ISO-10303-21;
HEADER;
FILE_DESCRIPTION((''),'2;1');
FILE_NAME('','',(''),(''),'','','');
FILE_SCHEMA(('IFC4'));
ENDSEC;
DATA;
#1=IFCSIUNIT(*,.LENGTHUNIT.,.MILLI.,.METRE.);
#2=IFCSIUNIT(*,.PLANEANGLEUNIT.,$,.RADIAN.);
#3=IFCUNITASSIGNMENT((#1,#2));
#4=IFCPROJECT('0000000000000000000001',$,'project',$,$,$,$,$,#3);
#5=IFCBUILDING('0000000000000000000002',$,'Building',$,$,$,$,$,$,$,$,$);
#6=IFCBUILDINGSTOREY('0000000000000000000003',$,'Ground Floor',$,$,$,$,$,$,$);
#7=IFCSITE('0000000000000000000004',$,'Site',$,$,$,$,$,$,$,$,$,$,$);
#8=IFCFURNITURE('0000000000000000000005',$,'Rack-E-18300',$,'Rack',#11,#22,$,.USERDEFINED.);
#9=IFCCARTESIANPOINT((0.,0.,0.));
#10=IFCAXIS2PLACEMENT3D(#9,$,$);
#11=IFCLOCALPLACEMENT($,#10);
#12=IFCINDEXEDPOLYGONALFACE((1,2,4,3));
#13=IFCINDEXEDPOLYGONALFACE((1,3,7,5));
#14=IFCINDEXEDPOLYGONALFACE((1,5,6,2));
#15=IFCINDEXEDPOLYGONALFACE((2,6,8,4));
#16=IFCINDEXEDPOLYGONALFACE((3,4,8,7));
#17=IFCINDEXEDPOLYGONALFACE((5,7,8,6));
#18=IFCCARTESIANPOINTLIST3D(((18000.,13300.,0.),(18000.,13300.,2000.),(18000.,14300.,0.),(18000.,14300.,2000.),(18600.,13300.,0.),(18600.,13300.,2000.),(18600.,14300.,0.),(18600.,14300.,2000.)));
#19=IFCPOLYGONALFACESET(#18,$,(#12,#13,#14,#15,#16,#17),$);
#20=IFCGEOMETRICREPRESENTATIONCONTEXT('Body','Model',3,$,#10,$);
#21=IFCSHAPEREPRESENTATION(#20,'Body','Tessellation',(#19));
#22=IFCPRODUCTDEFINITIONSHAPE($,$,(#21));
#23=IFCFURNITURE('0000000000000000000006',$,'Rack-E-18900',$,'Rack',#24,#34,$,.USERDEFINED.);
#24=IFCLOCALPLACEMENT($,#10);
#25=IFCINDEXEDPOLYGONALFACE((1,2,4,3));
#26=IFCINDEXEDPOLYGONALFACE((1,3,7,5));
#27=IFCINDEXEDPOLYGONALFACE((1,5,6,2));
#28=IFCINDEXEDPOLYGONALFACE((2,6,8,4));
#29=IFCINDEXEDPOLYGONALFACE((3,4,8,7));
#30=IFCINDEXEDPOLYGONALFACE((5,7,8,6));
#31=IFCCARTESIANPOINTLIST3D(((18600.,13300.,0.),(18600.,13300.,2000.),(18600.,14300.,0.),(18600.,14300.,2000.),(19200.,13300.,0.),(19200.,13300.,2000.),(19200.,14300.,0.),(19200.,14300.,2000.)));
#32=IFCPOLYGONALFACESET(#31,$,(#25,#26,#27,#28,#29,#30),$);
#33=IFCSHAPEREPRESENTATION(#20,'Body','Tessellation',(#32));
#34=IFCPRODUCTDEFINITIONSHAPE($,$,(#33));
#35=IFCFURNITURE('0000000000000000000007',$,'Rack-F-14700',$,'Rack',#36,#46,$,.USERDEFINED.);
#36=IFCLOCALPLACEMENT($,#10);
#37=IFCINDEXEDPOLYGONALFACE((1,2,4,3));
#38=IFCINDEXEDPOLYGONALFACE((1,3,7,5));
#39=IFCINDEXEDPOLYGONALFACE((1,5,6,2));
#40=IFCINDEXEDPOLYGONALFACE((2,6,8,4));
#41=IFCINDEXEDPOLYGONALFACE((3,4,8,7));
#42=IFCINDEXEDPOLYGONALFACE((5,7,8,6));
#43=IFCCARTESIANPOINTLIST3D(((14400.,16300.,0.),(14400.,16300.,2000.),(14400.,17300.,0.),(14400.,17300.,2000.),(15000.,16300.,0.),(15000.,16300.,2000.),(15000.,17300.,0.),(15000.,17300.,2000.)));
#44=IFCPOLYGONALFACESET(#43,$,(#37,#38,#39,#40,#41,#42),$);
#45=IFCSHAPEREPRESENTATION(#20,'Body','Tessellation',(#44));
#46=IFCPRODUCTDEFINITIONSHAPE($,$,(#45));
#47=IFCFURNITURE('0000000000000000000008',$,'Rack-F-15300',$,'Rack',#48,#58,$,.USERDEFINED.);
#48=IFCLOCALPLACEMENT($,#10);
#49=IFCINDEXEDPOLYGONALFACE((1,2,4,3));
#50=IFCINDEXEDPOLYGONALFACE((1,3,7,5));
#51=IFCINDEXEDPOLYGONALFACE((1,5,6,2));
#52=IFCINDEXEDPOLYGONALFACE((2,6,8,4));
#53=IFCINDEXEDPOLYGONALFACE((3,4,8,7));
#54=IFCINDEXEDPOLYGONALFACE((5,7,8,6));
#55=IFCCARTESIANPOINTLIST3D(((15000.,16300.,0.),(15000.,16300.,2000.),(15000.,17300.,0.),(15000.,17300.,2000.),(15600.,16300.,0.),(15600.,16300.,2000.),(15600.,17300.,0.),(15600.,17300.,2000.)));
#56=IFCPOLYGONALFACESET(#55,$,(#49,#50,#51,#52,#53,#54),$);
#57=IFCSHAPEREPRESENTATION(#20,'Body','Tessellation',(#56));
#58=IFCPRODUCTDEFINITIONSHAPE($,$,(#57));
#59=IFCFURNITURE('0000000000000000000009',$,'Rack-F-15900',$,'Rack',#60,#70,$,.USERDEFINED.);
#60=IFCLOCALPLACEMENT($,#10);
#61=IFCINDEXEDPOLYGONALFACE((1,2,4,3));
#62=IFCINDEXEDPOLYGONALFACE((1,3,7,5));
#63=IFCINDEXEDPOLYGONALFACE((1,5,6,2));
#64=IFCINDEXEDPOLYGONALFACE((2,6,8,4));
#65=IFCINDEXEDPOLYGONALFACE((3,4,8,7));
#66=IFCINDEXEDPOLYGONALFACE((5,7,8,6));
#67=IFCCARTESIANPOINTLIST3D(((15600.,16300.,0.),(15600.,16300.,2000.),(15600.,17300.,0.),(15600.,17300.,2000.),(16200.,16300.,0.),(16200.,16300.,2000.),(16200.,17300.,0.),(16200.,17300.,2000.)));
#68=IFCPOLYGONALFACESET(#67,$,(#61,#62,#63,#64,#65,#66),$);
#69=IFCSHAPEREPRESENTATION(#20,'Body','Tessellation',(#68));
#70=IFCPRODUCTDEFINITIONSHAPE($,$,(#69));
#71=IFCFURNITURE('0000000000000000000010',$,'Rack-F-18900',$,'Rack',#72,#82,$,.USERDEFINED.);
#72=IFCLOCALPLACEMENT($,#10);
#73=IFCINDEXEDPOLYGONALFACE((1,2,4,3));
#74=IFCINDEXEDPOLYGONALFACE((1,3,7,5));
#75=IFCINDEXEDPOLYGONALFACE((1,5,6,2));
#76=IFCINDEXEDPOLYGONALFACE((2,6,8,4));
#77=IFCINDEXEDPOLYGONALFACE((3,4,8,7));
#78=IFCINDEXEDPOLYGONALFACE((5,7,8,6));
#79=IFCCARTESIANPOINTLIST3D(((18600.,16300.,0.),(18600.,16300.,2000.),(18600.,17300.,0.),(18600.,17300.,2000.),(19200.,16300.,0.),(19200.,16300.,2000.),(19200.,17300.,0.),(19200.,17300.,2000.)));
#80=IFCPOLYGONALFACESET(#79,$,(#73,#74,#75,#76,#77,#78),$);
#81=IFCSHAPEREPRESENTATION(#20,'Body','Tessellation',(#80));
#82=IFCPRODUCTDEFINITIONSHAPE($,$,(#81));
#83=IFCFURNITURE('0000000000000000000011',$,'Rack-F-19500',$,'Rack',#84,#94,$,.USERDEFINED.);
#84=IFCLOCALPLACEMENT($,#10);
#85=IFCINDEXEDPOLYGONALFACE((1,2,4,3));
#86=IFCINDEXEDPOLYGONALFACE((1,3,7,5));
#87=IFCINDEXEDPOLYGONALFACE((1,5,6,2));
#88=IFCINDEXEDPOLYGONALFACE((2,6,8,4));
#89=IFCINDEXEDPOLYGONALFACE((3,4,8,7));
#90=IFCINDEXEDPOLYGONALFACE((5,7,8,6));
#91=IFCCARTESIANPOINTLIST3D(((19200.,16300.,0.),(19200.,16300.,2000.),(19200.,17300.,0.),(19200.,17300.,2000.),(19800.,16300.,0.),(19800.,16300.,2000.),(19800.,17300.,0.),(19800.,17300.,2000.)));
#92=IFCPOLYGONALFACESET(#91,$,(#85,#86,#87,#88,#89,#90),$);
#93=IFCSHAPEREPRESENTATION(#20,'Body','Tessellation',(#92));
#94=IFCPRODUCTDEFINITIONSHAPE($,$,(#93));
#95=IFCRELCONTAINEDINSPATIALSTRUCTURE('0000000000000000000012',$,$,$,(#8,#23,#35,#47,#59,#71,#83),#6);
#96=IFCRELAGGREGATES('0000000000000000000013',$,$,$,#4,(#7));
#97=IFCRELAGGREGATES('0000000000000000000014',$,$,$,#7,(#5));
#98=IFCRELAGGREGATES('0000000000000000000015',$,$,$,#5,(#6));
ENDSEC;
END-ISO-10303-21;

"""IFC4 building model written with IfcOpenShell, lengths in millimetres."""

from ifc_helpers import new_model, si_unit, frame, origin, place, context, project, spatial, rectangle, extrude, element, save


model = new_model("IFC4")

# Units and contexts
model_context = context("Model", 3, world=origin(), identifier="Body")
ifc_project = project(units=[si_unit("LENGTHUNIT", "METRE", prefix="MILLI"), si_unit("PLANEANGLEUNIT", "RADIAN")])

# Site, building, storey
site = spatial("IfcSite", under=ifc_project, Name="Site")
building = spatial("IfcBuilding", under=site, Name="Building")
storey = spatial("IfcBuildingStorey", under=building, Name="Ground Floor")

# Furniture
for number, where, z_axis, x_axis, name in (
    (1, (18300.0, 13800.0, 0.0), (0.0, 0.0, 1.0), (1.0, 0.0, 0.0), "Rack-E-18300"),
    (2, (18900.0, 13800.0, 0.0), (0.0, 0.0, 1.0), (1.0, 0.0, 0.0), "Rack-E-18900"),
    (3, (14700.0, 16800.0, 0.0), (0.0, 0.0, 1.0), (1.0, 0.0, 0.0), "Rack-F-14700"),
    (4, (15300.0, 16800.0, 0.0), (0.0, 0.0, 1.0), (1.0, 0.0, 0.0), "Rack-F-15300"),
    (5, (15900.0, 16800.0, 0.0), (0.0, 0.0, 1.0), (1.0, 0.0, 0.0), "Rack-F-15900"),
    (6, (18900.0, 16800.0, 0.0), (0.0, 0.0, 1.0), (1.0, 0.0, 0.0), "Rack-F-18900"),
    (7, (19500.0, 16800.0, 0.0), (0.0, 0.0, 1.0), (1.0, 0.0, 0.0), "Rack-F-19500"),
):
    element("IfcFurniture", number, at=place(None, frame(where, z_axis=z_axis, x_axis=x_axis)), inside=storey, Name=name, ObjectType="Rack", PredefinedType="USERDEFINED", context=model_context, shape_type="SweptSolid", body=[
        extrude(rectangle(XDim=600.0, YDim=1000.0), origin(), (0.0, 0.0, 1.0), 2000.0),
    ])

save(model, "model.ifc")
